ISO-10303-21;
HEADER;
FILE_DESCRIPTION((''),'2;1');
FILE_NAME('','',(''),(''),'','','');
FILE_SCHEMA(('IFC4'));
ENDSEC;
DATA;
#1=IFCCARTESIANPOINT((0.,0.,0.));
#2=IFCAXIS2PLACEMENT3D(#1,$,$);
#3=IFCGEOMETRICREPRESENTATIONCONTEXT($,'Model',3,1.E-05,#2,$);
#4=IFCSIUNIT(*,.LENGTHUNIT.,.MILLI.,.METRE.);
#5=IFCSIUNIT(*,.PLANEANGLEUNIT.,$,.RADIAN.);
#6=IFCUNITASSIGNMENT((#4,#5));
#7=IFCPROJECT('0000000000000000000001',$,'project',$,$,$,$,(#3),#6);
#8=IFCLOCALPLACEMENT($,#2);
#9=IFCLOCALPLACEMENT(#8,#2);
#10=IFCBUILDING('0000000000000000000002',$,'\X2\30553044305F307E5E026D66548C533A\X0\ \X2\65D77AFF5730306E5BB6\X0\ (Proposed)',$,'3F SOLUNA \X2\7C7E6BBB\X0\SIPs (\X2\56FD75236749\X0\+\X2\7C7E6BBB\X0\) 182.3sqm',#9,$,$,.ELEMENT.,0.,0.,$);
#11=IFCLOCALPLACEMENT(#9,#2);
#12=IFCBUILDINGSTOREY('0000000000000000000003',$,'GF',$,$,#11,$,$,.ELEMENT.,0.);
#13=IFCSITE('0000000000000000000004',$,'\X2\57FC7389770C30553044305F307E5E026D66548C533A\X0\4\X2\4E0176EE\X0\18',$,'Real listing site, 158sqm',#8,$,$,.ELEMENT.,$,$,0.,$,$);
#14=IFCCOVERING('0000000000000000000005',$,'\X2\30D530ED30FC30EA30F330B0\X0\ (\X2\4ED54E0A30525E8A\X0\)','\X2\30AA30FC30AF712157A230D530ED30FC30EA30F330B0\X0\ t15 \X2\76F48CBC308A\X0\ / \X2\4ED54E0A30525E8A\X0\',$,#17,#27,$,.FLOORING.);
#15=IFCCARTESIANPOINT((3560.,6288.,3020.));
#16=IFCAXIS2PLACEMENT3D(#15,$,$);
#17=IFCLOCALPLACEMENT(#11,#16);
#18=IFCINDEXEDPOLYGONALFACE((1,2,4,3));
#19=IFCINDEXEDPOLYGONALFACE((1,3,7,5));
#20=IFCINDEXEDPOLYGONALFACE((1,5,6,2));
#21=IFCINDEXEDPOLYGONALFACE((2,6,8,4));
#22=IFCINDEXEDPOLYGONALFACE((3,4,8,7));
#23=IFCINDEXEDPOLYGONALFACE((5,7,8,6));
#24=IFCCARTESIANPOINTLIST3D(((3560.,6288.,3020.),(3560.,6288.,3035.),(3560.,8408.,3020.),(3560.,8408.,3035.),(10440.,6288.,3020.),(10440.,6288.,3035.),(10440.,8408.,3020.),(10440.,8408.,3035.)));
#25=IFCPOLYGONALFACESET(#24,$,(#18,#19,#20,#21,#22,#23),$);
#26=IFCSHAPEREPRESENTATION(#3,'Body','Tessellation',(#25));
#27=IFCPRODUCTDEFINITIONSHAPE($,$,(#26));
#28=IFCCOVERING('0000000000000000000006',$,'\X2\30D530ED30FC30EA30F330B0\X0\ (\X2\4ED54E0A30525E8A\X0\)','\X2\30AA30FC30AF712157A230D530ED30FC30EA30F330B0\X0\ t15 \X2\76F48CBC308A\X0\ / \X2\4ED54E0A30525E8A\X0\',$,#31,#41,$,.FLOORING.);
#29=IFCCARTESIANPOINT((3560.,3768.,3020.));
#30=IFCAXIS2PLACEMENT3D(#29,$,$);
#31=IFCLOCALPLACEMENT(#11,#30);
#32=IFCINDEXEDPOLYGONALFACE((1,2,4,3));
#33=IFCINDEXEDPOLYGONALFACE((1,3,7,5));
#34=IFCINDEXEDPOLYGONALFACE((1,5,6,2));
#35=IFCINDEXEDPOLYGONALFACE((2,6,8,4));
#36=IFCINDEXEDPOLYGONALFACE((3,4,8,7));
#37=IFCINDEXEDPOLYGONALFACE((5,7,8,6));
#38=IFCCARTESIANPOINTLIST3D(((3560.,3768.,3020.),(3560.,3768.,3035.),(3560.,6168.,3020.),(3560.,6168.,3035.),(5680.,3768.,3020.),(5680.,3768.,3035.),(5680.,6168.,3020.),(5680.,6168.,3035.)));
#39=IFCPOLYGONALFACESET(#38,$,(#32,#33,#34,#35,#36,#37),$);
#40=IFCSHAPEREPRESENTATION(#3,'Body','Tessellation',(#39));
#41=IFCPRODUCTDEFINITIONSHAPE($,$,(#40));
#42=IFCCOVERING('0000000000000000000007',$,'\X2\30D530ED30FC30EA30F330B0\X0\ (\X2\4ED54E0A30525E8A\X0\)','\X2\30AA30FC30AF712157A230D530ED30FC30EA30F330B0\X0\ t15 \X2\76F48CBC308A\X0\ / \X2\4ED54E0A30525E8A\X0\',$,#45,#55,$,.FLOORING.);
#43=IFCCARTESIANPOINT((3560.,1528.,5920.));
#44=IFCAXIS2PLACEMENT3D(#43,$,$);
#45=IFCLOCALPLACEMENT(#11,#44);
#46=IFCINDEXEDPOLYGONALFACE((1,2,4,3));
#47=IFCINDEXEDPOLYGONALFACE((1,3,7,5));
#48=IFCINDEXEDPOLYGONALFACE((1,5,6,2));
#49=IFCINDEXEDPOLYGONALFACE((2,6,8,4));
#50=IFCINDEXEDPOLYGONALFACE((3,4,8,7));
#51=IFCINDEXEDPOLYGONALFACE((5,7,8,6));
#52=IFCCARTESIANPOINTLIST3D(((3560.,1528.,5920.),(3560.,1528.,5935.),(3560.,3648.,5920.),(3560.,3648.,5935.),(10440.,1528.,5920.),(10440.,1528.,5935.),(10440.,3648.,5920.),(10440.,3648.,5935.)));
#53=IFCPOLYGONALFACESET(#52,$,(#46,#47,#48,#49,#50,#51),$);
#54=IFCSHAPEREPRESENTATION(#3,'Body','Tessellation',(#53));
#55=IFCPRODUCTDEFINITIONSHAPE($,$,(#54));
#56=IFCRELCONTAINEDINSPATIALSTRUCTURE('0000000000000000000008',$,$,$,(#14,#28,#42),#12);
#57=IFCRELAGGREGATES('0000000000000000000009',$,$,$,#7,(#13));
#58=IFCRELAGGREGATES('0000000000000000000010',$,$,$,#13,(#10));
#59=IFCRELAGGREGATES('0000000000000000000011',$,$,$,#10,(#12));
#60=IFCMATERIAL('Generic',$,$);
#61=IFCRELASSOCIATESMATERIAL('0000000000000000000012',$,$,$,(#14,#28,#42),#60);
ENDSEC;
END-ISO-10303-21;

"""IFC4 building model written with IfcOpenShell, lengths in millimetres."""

from ifc_helpers import new_model, si_unit, frame, frame_2d, origin, place, context, project, spatial, rectangle, extrude, material, element, save


model = new_model("IFC4")

# Units and contexts
model_context = context("Model", 3, precision=1e-05, world=origin())
ifc_project = project(units=[si_unit("LENGTHUNIT", "METRE", prefix="MILLI"), si_unit("PLANEANGLEUNIT", "RADIAN")], contexts=[model_context])

# Site, building, storey
site_placement = place(None, origin())
site = spatial("IfcSite", under=ifc_project, at=site_placement, Name="埼玉県さいたま市浦和区4丁目18", ObjectType="Real listing site, 158sqm", CompositionType="ELEMENT", RefElevation=0.0)
building_placement = place(site_placement, origin())
building = spatial("IfcBuilding", under=site, at=building_placement, Name="さいたま市浦和区 旗竿地の家 (Proposed)", ObjectType="3F SOLUNA 籾殻SIPs (国産杉+籾殻) 182.3sqm", CompositionType="ELEMENT", ElevationOfRefHeight=0.0, ElevationOfTerrain=0.0)
storey_placement = place(building_placement, origin())
storey = spatial("IfcBuildingStorey", under=building, at=storey_placement, Name="GF", CompositionType="ELEMENT", Elevation=0.0)

# Shared definitions
ifc_material_1 = material(Name="Generic")

# Coverings
covering_1_placement = place(storey_placement, frame((3560.0, 6288.0, 3020.0)))
element("IfcCovering", 1, at=covering_1_placement, inside=storey, material=ifc_material_1, Name="フローリング (仕上げ床)", Description="オーク無垢フローリング t15 直貼り / 仕上げ床", PredefinedType="FLOORING", context=model_context, shape_type="SweptSolid", body=[
    extrude(rectangle(XDim=6880.0, YDim=2120.0, at=frame_2d((3440.0, 1060.0))), frame((3560.0, 6288.0, 3020.0)), (0.0, 0.0, 1.0), 15.0),
])
covering_2_placement = place(storey_placement, frame((3560.0, 3768.0, 3020.0)))
element("IfcCovering", 2, at=covering_2_placement, inside=storey, material=ifc_material_1, Name="フローリング (仕上げ床)", Description="オーク無垢フローリング t15 直貼り / 仕上げ床", PredefinedType="FLOORING", context=model_context, shape_type="SweptSolid", body=[
    extrude(rectangle(XDim=2120.0, YDim=2400.0, at=frame_2d((1060.0, 1200.0))), frame((3560.0, 3768.0, 3020.0)), (0.0, 0.0, 1.0), 15.0),
])
covering_3_placement = place(storey_placement, frame((3560.0, 1528.0, 5920.0)))
element("IfcCovering", 3, at=covering_3_placement, inside=storey, material=ifc_material_1, Name="フローリング (仕上げ床)", Description="オーク無垢フローリング t15 直貼り / 仕上げ床", PredefinedType="FLOORING", context=model_context, shape_type="SweptSolid", body=[
    extrude(rectangle(XDim=6880.0, YDim=2120.0, at=frame_2d((3440.0, 1060.0))), frame((3560.0, 1528.0, 5920.0)), (0.0, 0.0, 1.0), 15.0),
])

save(model, "model.ifc")
